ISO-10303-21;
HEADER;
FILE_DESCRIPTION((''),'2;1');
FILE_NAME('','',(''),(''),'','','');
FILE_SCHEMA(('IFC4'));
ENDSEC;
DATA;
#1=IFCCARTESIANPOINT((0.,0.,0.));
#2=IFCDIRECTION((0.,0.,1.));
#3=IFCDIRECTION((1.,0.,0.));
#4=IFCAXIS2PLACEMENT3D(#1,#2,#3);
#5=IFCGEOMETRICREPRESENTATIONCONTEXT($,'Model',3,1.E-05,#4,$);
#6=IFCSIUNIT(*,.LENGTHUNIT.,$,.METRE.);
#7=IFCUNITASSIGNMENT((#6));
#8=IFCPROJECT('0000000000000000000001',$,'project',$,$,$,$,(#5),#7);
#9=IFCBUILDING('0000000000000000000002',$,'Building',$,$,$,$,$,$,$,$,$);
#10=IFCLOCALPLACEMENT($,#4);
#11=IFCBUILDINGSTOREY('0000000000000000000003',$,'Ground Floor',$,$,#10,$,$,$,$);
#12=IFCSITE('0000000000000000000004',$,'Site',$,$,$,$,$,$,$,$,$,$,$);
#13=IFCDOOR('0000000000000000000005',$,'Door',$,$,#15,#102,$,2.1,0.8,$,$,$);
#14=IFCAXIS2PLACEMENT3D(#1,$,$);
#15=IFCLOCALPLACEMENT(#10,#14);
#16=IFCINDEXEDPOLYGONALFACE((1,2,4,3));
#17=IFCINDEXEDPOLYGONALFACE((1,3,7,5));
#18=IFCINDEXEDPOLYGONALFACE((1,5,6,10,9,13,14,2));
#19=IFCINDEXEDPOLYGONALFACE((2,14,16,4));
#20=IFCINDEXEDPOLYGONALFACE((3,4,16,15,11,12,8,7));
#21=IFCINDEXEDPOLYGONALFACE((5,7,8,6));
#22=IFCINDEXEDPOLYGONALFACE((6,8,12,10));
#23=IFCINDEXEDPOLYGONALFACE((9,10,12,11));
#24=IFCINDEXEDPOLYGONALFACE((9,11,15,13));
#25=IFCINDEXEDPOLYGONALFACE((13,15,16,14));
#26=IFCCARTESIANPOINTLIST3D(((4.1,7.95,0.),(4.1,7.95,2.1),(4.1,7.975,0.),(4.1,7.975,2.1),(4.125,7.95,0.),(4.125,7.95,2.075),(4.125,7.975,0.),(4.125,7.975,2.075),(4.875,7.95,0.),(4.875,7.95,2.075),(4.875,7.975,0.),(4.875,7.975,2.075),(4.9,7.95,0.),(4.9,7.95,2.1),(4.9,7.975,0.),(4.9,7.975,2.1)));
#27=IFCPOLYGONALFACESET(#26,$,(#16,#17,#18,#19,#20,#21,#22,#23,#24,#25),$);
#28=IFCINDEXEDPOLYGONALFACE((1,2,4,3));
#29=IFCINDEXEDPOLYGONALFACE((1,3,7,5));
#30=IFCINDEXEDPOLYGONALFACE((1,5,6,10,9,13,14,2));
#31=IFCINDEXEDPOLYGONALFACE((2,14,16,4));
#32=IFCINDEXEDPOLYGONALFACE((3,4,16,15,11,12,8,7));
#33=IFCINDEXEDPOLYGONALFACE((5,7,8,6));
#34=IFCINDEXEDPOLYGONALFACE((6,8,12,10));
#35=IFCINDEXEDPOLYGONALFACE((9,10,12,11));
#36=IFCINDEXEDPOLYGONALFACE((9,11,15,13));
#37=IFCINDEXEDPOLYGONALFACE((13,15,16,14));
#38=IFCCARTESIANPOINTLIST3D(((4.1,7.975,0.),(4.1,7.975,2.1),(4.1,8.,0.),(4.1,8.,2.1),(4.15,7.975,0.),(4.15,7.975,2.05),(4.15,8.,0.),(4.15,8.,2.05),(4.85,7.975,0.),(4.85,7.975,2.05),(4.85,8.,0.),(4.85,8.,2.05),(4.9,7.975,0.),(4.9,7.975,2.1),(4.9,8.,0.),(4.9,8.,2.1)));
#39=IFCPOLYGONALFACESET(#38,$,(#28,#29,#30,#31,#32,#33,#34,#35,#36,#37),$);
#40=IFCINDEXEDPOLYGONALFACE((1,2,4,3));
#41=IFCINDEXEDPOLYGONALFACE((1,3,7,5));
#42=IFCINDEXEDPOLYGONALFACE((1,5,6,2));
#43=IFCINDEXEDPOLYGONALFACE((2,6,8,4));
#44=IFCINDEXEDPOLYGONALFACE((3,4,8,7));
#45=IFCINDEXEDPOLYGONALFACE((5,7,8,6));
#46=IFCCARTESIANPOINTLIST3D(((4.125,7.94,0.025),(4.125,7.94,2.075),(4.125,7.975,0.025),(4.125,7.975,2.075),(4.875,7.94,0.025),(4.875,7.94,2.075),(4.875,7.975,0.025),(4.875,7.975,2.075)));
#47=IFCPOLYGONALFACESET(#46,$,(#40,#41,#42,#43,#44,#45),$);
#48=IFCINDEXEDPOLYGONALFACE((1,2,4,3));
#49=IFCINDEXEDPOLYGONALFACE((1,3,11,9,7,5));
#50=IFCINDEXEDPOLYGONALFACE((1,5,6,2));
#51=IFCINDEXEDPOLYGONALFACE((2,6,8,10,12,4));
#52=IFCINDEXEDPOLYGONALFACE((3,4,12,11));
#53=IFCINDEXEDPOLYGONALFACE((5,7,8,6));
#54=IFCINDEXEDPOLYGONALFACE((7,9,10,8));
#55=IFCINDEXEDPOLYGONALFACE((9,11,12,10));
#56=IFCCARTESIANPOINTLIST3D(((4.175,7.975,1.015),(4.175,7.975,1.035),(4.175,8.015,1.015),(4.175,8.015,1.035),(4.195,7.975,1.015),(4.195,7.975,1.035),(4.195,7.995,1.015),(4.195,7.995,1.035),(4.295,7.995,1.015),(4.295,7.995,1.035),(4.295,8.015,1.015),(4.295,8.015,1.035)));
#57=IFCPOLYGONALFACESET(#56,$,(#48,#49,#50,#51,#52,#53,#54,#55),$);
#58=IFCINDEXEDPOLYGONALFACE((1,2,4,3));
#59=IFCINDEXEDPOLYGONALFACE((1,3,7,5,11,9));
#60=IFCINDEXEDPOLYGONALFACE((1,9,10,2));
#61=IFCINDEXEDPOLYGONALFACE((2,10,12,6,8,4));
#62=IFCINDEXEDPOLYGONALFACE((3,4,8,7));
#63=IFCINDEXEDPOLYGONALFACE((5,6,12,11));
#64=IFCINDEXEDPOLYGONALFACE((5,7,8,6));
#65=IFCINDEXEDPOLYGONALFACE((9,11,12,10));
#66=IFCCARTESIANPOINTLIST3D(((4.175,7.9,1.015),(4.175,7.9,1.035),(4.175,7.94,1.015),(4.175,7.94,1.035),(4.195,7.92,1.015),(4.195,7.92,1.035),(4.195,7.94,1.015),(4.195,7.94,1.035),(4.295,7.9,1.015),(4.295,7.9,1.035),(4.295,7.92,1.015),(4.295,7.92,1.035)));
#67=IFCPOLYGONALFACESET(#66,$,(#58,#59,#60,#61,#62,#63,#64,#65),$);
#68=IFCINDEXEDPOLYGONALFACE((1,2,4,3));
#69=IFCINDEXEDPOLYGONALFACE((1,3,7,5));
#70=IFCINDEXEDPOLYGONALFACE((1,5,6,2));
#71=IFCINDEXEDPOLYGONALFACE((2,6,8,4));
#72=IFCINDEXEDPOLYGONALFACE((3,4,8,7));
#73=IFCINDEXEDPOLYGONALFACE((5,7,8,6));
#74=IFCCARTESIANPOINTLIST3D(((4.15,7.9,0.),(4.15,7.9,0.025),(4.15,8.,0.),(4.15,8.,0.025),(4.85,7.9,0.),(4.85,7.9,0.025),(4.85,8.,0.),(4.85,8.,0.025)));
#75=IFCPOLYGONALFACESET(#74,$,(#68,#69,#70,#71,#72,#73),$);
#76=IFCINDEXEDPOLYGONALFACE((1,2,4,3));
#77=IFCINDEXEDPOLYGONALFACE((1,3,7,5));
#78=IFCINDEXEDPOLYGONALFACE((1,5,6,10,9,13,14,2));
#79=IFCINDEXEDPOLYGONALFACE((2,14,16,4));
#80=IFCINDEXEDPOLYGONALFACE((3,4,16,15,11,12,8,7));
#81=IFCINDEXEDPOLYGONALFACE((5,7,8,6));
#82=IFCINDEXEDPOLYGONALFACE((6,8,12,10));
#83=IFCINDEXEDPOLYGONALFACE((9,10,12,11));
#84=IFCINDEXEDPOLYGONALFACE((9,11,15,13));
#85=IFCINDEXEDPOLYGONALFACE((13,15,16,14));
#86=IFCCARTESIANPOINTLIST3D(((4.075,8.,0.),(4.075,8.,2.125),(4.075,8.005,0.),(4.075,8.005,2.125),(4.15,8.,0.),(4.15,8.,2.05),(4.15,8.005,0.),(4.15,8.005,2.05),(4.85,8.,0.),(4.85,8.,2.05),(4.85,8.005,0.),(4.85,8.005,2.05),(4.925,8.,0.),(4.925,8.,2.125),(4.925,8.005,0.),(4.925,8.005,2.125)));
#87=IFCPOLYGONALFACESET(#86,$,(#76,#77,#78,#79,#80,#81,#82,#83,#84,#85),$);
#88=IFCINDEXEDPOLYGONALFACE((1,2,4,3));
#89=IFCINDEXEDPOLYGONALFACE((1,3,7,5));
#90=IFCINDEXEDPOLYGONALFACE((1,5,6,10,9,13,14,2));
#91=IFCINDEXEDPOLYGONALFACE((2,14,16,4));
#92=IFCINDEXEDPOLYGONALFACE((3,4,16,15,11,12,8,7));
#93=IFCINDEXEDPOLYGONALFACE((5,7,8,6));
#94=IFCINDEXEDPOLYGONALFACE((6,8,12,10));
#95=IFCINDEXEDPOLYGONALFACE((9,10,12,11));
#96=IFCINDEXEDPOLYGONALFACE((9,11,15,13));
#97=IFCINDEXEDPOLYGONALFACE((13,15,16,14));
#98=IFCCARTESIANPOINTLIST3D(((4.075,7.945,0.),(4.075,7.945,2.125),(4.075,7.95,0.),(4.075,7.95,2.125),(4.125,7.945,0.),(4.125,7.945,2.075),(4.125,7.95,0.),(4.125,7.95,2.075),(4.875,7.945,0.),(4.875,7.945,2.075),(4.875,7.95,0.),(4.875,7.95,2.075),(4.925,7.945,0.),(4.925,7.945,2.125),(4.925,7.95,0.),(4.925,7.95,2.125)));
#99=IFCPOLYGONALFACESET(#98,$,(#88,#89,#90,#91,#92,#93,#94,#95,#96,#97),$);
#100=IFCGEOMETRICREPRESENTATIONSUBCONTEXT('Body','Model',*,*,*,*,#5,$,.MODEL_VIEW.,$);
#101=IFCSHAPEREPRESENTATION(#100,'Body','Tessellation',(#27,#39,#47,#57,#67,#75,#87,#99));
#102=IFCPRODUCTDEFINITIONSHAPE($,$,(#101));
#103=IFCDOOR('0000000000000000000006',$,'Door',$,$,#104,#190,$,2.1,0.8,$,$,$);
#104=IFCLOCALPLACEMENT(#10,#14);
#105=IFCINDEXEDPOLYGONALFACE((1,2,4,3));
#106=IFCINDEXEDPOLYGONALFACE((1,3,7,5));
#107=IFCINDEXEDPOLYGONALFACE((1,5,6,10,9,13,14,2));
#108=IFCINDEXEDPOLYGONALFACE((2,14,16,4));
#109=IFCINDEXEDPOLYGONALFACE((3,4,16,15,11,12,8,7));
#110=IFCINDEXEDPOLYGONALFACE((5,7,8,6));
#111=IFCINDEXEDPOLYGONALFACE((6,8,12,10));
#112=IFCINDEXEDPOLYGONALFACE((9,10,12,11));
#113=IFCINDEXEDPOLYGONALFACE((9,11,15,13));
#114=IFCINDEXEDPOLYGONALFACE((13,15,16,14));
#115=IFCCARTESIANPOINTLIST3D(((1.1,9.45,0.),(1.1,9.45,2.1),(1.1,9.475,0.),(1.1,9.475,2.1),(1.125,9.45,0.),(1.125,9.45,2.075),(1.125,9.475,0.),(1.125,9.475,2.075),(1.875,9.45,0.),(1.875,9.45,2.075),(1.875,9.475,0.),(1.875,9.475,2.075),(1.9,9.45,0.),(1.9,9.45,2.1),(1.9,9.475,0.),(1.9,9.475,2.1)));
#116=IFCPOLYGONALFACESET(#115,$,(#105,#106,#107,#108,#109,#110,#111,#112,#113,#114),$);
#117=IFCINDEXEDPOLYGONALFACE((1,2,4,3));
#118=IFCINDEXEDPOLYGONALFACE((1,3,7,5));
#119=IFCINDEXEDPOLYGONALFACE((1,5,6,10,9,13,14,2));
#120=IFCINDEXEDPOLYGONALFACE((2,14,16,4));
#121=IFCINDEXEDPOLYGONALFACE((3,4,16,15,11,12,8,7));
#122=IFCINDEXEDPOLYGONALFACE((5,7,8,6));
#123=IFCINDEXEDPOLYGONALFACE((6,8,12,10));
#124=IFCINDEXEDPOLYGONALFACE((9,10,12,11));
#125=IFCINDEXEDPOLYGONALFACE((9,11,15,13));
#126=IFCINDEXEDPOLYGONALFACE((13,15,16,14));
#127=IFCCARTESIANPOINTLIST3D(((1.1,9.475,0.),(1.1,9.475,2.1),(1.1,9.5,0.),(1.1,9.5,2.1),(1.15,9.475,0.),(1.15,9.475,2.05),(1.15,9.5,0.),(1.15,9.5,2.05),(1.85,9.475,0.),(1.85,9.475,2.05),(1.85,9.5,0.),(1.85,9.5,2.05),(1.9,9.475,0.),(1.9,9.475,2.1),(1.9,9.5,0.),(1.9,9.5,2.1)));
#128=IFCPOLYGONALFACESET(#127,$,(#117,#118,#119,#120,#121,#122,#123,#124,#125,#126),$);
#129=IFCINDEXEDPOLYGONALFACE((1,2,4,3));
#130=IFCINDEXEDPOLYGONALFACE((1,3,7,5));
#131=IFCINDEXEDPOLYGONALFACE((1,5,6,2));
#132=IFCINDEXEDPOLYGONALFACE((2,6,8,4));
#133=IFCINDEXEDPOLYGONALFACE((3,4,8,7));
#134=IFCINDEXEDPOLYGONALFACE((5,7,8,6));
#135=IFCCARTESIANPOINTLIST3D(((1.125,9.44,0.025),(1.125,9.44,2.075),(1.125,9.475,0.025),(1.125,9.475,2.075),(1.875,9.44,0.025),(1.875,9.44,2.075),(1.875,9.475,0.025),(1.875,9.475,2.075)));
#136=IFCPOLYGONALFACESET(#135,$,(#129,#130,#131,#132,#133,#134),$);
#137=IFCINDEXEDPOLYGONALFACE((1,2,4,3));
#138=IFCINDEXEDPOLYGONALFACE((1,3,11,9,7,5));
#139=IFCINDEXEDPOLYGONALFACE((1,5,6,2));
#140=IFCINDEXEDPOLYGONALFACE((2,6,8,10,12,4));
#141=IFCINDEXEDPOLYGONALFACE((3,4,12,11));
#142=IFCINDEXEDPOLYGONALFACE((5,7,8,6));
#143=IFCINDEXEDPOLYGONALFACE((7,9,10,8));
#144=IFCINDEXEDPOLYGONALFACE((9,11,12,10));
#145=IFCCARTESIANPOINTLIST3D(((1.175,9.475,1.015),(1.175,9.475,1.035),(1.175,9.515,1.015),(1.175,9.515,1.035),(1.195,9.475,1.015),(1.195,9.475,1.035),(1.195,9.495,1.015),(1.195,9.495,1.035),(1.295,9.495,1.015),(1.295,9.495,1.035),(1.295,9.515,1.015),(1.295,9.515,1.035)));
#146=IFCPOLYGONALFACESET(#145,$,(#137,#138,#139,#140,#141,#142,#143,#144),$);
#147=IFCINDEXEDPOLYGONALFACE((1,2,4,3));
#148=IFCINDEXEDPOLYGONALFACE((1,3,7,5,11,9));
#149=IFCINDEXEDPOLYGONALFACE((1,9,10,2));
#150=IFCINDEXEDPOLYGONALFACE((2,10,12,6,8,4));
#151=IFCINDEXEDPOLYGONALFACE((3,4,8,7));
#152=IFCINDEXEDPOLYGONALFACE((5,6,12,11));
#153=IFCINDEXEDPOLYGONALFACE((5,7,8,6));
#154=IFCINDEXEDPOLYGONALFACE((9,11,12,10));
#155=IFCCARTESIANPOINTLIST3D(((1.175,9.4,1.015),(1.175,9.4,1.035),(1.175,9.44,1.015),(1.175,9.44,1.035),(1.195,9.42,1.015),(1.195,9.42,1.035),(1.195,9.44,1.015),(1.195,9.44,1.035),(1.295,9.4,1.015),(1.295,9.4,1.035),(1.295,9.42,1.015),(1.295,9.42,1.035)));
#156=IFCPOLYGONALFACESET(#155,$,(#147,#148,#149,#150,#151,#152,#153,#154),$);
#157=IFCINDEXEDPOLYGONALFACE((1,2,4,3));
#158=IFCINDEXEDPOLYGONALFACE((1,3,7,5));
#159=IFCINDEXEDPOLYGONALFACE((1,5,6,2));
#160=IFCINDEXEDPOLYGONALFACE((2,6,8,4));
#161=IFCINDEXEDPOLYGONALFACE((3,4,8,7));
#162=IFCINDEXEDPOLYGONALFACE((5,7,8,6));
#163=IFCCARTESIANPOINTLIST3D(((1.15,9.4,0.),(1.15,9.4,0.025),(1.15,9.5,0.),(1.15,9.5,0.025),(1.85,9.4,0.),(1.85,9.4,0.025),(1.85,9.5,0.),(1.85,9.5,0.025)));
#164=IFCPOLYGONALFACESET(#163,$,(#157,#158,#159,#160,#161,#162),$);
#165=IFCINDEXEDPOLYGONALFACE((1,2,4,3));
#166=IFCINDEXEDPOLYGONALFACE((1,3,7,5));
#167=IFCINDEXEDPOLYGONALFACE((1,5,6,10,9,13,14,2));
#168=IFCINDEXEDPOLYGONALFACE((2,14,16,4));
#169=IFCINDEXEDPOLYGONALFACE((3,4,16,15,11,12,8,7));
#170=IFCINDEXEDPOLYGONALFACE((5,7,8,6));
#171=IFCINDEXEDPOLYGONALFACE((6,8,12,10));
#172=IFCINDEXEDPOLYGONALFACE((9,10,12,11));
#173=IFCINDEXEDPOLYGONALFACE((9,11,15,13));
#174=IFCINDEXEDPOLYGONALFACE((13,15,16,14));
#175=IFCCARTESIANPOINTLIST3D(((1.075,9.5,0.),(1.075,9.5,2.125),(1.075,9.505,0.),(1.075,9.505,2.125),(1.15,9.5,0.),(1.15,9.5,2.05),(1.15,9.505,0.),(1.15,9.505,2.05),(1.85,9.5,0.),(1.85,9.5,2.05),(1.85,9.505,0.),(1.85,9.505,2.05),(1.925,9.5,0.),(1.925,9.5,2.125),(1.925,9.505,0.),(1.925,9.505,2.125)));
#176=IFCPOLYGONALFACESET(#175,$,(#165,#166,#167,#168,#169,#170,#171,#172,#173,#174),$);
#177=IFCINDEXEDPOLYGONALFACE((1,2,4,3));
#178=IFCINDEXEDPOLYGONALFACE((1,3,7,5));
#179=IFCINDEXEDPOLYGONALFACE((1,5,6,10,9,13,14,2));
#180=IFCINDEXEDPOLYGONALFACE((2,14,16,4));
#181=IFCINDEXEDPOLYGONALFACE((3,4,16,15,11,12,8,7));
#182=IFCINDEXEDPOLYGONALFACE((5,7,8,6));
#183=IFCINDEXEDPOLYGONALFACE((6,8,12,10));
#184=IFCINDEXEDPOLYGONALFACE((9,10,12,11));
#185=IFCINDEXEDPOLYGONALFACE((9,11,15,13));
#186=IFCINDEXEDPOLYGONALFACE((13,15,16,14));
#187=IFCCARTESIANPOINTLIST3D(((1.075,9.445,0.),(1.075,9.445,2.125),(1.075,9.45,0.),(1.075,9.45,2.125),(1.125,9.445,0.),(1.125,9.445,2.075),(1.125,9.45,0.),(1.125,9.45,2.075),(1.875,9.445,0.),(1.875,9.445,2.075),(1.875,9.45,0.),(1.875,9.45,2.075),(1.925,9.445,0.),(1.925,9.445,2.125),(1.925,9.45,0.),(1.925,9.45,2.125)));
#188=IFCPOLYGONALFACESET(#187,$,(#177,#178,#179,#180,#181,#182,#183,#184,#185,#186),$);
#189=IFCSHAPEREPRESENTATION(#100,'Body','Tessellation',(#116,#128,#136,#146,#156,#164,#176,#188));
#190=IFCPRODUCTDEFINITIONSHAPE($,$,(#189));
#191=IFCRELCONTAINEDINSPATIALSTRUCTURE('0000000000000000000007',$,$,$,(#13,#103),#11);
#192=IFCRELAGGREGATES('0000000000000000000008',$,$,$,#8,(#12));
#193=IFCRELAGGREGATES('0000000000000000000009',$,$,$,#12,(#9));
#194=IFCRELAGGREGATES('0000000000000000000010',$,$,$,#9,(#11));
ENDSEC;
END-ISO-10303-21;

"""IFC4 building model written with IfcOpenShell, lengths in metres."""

from ifc_helpers import new_model, si_unit, frame, origin_with_axes, place, context, subcontext, project, spatial, line, indexed_curve, outline, extrude, element, save


model = new_model("IFC4")

# Units and contexts
model_context = context("Model", 3, precision=1e-05, world=origin_with_axes())
body_context = subcontext(model_context, "Body", "Model", "MODEL_VIEW")
ifc_project = project(units=[si_unit("LENGTHUNIT", "METRE")], contexts=[model_context])

# Site, building, storey
site = spatial("IfcSite", under=ifc_project, Name="Site")
building = spatial("IfcBuilding", under=site, Name="Building")
storey_placement = place(None, origin_with_axes())
storey = spatial("IfcBuildingStorey", under=building, at=storey_placement, Name="Ground Floor")

# Doors
door_1_placement = place(storey_placement, frame((4.9, 8.0, 0.0), z_axis=(0.0, 0.0, 1.0), x_axis=(-1.0, 0.0, 0.0)))
element("IfcDoor", 1, at=door_1_placement, inside=storey, Name="Door", OverallHeight=2.1, OverallWidth=0.8, context=body_context, shape_type="SweptSolid", body=[
    extrude(outline(indexed_curve([(0.0, 0.0), (0.0, 2.1), (0.8, 2.1), (0.8, 0.0), (0.775, 0.0), (0.775, 2.075), (0.025, 2.075), (0.025, 0.0)], segments=[line(1, 2, 3, 4, 5, 6, 7, 8, 1)])), frame((0.0, 0.025, 0.0), z_axis=(0.0, -1.0, 0.0), x_axis=(1.0, 0.0, 0.0)), (0.0, 0.0, -1.0), 0.025),
    extrude(outline(indexed_curve([(0.0, 0.0), (0.0, 2.1), (0.8, 2.1), (0.8, 0.0), (0.75, 0.0), (0.75, 2.05), (0.05, 2.05), (0.05, 0.0)], segments=[line(1, 2, 3, 4, 5, 6, 7, 8, 1)])), frame((0.0, 0.0, 0.0), z_axis=(0.0, -1.0, 0.0), x_axis=(1.0, 0.0, 0.0)), (0.0, 0.0, -1.0), 0.025),
    extrude(outline(indexed_curve([(0.0, 0.0), (0.75, 0.0), (0.75, 0.035), (0.0, 0.035)], segments=[line(1, 2, 3, 4, 1)])), frame((0.025, 0.025, 0.025), z_axis=(0.0, 0.0, 1.0), x_axis=(1.0, 0.0, 0.0)), (0.0, 0.0, 1.0), 2.05),
    extrude(outline(indexed_curve([(0.0, 0.0), (0.0, -0.04), (-0.12, -0.04), (-0.12, -0.02), (-0.02, -0.02), (-0.02, 0.0)], segments=[line(1, 2, 3, 4, 5, 6, 1)])), frame((0.725, 0.025, 1.015), z_axis=(0.0, 0.0, 1.0), x_axis=(1.0, 0.0, 0.0)), (0.0, 0.0, 1.0), 0.02),
    extrude(outline(indexed_curve([(0.0, 0.0), (0.0, 0.04), (-0.12, 0.04), (-0.12, 0.02), (-0.02, 0.02), (-0.02, 0.0)], segments=[line(1, 2, 3, 4, 5, 6, 1)])), frame((0.725, 0.06, 1.015), z_axis=(0.0, 0.0, 1.0), x_axis=(1.0, 0.0, 0.0)), (0.0, 0.0, 1.0), 0.02),
    extrude(outline(indexed_curve([(0.0, 0.0), (0.7, 0.0), (0.7, 0.1), (0.0, 0.1)], segments=[line(1, 2, 3, 4, 1)])), frame((0.05, 0.0, 0.0), z_axis=(0.0, 0.0, 1.0), x_axis=(1.0, 0.0, 0.0)), (0.0, 0.0, 1.0), 0.025),
    extrude(outline(indexed_curve([(0.0, 0.0), (0.0, 2.125), (0.85, 2.125), (0.85, 0.0), (0.775, 0.0), (0.775, 2.05), (0.075, 2.05), (0.075, 0.0)], segments=[line(1, 2, 3, 4, 5, 6, 7, 8, 1)])), frame((-0.025, -0.005, 0.0), z_axis=(0.0, -1.0, 0.0), x_axis=(1.0, 0.0, 0.0)), (0.0, 0.0, -1.0), 0.005),
    extrude(outline(indexed_curve([(0.0, 0.0), (0.0, 2.125), (0.85, 2.125), (0.85, 0.0), (0.8, 0.0), (0.8, 2.075), (0.05, 2.075), (0.05, 0.0)], segments=[line(1, 2, 3, 4, 5, 6, 7, 8, 1)])), frame((-0.025, 0.05, 0.0), z_axis=(0.0, -1.0, 0.0), x_axis=(1.0, 0.0, 0.0)), (0.0, 0.0, -1.0), 0.005),
])
door_2_placement = place(storey_placement, frame((1.9, 9.5, 0.0), z_axis=(0.0, 0.0, 1.0), x_axis=(-1.0, 0.0, 0.0)))
element("IfcDoor", 2, at=door_2_placement, inside=storey, Name="Door", OverallHeight=2.1, OverallWidth=0.8, context=body_context, shape_type="SweptSolid", body=[
    extrude(outline(indexed_curve([(0.0, 0.0), (0.0, 2.1), (0.8, 2.1), (0.8, 0.0), (0.775, 0.0), (0.775, 2.075), (0.025, 2.075), (0.025, 0.0)], segments=[line(1, 2, 3, 4, 5, 6, 7, 8, 1)])), frame((0.0, 0.025, 0.0), z_axis=(0.0, -1.0, 0.0), x_axis=(1.0, 0.0, 0.0)), (0.0, 0.0, -1.0), 0.025),
    extrude(outline(indexed_curve([(0.0, 0.0), (0.0, 2.1), (0.8, 2.1), (0.8, 0.0), (0.75, 0.0), (0.75, 2.05), (0.05, 2.05), (0.05, 0.0)], segments=[line(1, 2, 3, 4, 5, 6, 7, 8, 1)])), frame((0.0, 0.0, 0.0), z_axis=(0.0, -1.0, 0.0), x_axis=(1.0, 0.0, 0.0)), (0.0, 0.0, -1.0), 0.025),
    extrude(outline(indexed_curve([(0.0, 0.0), (0.75, 0.0), (0.75, 0.035), (0.0, 0.035)], segments=[line(1, 2, 3, 4, 1)])), frame((0.025, 0.025, 0.025), z_axis=(0.0, 0.0, 1.0), x_axis=(1.0, 0.0, 0.0)), (0.0, 0.0, 1.0), 2.05),
    extrude(outline(indexed_curve([(0.0, 0.0), (0.0, -0.04), (-0.12, -0.04), (-0.12, -0.02), (-0.02, -0.02), (-0.02, 0.0)], segments=[line(1, 2, 3, 4, 5, 6, 1)])), frame((0.725, 0.025, 1.015), z_axis=(0.0, 0.0, 1.0), x_axis=(1.0, 0.0, 0.0)), (0.0, 0.0, 1.0), 0.02),
    extrude(outline(indexed_curve([(0.0, 0.0), (0.0, 0.04), (-0.12, 0.04), (-0.12, 0.02), (-0.02, 0.02), (-0.02, 0.0)], segments=[line(1, 2, 3, 4, 5, 6, 1)])), frame((0.725, 0.06, 1.015), z_axis=(0.0, 0.0, 1.0), x_axis=(1.0, 0.0, 0.0)), (0.0, 0.0, 1.0), 0.02),
    extrude(outline(indexed_curve([(0.0, 0.0), (0.7, 0.0), (0.7, 0.1), (0.0, 0.1)], segments=[line(1, 2, 3, 4, 1)])), frame((0.05, 0.0, 0.0), z_axis=(0.0, 0.0, 1.0), x_axis=(1.0, 0.0, 0.0)), (0.0, 0.0, 1.0), 0.025),
    extrude(outline(indexed_curve([(0.0, 0.0), (0.0, 2.125), (0.85, 2.125), (0.85, 0.0), (0.775, 0.0), (0.775, 2.05), (0.075, 2.05), (0.075, 0.0)], segments=[line(1, 2, 3, 4, 5, 6, 7, 8, 1)])), frame((-0.025, -0.005, 0.0), z_axis=(0.0, -1.0, 0.0), x_axis=(1.0, 0.0, 0.0)), (0.0, 0.0, -1.0), 0.005),
    extrude(outline(indexed_curve([(0.0, 0.0), (0.0, 2.125), (0.85, 2.125), (0.85, 0.0), (0.8, 0.0), (0.8, 2.075), (0.05, 2.075), (0.05, 0.0)], segments=[line(1, 2, 3, 4, 5, 6, 7, 8, 1)])), frame((-0.025, 0.05, 0.0), z_axis=(0.0, -1.0, 0.0), x_axis=(1.0, 0.0, 0.0)), (0.0, 0.0, -1.0), 0.005),
])

save(model, "model.ifc")
